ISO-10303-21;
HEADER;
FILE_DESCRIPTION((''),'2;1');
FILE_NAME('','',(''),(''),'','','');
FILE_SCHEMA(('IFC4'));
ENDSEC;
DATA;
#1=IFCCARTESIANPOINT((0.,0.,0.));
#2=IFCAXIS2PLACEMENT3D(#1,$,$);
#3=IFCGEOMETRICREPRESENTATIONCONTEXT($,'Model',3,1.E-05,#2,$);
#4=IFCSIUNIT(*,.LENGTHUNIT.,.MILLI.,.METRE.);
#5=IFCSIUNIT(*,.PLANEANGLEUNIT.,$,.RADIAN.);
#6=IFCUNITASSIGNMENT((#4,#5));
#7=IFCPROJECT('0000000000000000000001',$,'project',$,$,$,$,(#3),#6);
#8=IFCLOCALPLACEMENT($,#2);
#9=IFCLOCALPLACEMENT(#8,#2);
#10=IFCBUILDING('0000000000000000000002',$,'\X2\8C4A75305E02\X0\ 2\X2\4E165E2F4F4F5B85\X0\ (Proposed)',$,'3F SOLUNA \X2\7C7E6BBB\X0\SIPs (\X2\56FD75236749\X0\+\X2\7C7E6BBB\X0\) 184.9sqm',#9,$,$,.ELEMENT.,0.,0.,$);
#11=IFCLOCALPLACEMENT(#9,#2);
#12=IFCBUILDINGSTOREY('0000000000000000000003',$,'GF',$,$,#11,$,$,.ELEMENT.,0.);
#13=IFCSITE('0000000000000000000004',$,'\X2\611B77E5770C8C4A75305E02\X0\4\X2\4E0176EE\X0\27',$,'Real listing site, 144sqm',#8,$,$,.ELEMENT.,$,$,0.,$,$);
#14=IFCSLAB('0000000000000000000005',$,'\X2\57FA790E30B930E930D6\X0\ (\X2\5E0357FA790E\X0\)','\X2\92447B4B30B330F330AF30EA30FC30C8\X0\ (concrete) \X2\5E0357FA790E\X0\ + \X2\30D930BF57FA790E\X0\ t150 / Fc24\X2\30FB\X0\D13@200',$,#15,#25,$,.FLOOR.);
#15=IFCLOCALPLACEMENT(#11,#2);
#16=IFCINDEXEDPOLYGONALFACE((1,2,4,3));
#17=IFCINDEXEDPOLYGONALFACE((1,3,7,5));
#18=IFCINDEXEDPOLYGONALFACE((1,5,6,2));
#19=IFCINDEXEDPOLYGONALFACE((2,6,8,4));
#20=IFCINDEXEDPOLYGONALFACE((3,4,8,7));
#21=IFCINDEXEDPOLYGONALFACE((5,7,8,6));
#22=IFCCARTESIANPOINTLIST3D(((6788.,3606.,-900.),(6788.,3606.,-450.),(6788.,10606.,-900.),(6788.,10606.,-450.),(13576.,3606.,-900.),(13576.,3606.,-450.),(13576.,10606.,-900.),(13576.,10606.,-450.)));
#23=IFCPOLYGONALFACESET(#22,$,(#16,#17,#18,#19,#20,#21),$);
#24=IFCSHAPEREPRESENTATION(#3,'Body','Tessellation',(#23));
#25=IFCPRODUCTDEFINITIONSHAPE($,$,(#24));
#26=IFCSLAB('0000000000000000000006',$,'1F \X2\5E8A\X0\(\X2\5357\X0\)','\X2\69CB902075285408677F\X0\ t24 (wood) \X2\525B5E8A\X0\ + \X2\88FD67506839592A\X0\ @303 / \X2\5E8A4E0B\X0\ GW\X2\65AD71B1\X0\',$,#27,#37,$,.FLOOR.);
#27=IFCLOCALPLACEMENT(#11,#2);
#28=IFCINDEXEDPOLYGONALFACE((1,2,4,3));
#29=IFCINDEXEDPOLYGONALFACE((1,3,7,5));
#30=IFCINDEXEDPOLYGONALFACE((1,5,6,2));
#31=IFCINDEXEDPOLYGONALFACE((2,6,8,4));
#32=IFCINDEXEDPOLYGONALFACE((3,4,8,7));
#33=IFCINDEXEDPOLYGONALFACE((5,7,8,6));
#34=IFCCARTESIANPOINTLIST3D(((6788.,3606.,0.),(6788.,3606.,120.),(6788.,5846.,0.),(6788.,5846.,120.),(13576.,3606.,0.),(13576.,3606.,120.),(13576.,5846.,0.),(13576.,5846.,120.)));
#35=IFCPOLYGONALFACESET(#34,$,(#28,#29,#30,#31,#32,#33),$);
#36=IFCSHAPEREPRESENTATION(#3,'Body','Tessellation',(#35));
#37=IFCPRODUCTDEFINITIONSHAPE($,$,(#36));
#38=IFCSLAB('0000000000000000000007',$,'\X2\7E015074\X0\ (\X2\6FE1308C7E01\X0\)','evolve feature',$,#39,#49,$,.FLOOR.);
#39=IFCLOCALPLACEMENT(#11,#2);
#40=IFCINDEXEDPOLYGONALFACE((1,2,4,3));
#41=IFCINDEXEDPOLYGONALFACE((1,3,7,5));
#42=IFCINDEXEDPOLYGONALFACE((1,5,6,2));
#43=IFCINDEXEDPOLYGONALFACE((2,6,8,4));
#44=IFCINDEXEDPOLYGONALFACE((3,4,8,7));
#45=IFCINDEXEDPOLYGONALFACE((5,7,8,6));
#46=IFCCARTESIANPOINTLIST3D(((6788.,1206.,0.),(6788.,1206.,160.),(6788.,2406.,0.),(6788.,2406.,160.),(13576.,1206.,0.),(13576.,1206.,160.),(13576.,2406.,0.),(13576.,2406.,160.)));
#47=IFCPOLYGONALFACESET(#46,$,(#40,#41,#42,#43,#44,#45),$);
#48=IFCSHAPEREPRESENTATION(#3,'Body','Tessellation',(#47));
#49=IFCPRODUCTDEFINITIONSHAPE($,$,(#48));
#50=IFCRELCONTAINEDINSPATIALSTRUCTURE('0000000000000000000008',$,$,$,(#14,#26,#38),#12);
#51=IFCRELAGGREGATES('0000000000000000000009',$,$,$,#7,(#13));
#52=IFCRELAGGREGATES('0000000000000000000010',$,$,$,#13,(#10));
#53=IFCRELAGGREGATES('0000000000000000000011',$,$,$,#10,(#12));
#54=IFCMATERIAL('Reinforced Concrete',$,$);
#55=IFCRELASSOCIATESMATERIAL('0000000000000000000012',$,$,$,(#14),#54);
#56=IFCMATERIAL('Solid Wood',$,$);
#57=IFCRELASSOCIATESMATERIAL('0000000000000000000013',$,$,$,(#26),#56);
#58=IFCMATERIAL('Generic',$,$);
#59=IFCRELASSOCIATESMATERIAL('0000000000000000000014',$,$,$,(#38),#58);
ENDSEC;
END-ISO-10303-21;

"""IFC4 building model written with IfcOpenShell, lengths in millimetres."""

from ifc_helpers import new_model, si_unit, frame, frame_2d, origin, place, context, project, spatial, rectangle, extrude, material, element, save


model = new_model("IFC4")

# Units and contexts
model_context = context("Model", 3, precision=1e-05, world=origin())
ifc_project = project(units=[si_unit("LENGTHUNIT", "METRE", prefix="MILLI"), si_unit("PLANEANGLEUNIT", "RADIAN")], contexts=[model_context])

# Site, building, storey
site_placement = place(None, origin())
site = spatial("IfcSite", under=ifc_project, at=site_placement, Name="愛知県豊田市4丁目27", ObjectType="Real listing site, 144sqm", CompositionType="ELEMENT", RefElevation=0.0)
building_placement = place(site_placement, origin())
building = spatial("IfcBuilding", under=site, at=building_placement, Name="豊田市 2世帯住宅 (Proposed)", ObjectType="3F SOLUNA 籾殻SIPs (国産杉+籾殻) 184.9sqm", CompositionType="ELEMENT", ElevationOfRefHeight=0.0, ElevationOfTerrain=0.0)
storey_placement = place(building_placement, origin())
storey = spatial("IfcBuildingStorey", under=building, at=storey_placement, Name="GF", CompositionType="ELEMENT", Elevation=0.0)

# Slabs
ifc_material_1 = material(Name="Reinforced Concrete")
slab_1_placement = place(storey_placement, frame((3394.0, 1803.0, -450.0)))
element("IfcSlab", 1, at=slab_1_placement, inside=storey, material=ifc_material_1, Name="基礎スラブ (布基礎)", Description="鉄筋コンクリート (concrete) 布基礎 + ベタ基礎 t150 / Fc24・D13@200", PredefinedType="FLOOR", context=model_context, shape_type="SweptSolid", body=[
    extrude(rectangle(XDim=6788.0, YDim=7000.0, at=frame_2d((3394.0, 3500.0))), frame((3394.0, 1803.0, -450.0)), (0.0, 0.0, 1.0), 450.0),
])
ifc_material_2 = material(Name="Solid Wood")
slab_2_placement = place(storey_placement, frame((3394.0, 1803.0, 0.0)))
element("IfcSlab", 2, at=slab_2_placement, inside=storey, material=ifc_material_2, Name="1F 床(南)", Description="構造用合板 t24 (wood) 剛床 + 製材根太 @303 / 床下 GW断熱", PredefinedType="FLOOR", context=model_context, shape_type="SweptSolid", body=[
    extrude(rectangle(XDim=6788.0, YDim=2240.0, at=frame_2d((3394.0, 1120.0))), frame((3394.0, 1803.0, 0.0)), (0.0, 0.0, 1.0), 120.0),
])
ifc_material_3 = material(Name="Generic")
slab_3_placement = place(storey_placement, frame((3394.0, 603.0, 0.0)))
element("IfcSlab", 3, at=slab_3_placement, inside=storey, material=ifc_material_3, Name="縁側 (濡れ縁)", Description="evolve feature", PredefinedType="FLOOR", context=model_context, shape_type="SweptSolid", body=[
    extrude(rectangle(XDim=6788.0, YDim=1200.0, at=frame_2d((3394.0, 600.0))), frame((3394.0, 603.0, 0.0)), (0.0, 0.0, 1.0), 160.0),
])

save(model, "model.ifc")
